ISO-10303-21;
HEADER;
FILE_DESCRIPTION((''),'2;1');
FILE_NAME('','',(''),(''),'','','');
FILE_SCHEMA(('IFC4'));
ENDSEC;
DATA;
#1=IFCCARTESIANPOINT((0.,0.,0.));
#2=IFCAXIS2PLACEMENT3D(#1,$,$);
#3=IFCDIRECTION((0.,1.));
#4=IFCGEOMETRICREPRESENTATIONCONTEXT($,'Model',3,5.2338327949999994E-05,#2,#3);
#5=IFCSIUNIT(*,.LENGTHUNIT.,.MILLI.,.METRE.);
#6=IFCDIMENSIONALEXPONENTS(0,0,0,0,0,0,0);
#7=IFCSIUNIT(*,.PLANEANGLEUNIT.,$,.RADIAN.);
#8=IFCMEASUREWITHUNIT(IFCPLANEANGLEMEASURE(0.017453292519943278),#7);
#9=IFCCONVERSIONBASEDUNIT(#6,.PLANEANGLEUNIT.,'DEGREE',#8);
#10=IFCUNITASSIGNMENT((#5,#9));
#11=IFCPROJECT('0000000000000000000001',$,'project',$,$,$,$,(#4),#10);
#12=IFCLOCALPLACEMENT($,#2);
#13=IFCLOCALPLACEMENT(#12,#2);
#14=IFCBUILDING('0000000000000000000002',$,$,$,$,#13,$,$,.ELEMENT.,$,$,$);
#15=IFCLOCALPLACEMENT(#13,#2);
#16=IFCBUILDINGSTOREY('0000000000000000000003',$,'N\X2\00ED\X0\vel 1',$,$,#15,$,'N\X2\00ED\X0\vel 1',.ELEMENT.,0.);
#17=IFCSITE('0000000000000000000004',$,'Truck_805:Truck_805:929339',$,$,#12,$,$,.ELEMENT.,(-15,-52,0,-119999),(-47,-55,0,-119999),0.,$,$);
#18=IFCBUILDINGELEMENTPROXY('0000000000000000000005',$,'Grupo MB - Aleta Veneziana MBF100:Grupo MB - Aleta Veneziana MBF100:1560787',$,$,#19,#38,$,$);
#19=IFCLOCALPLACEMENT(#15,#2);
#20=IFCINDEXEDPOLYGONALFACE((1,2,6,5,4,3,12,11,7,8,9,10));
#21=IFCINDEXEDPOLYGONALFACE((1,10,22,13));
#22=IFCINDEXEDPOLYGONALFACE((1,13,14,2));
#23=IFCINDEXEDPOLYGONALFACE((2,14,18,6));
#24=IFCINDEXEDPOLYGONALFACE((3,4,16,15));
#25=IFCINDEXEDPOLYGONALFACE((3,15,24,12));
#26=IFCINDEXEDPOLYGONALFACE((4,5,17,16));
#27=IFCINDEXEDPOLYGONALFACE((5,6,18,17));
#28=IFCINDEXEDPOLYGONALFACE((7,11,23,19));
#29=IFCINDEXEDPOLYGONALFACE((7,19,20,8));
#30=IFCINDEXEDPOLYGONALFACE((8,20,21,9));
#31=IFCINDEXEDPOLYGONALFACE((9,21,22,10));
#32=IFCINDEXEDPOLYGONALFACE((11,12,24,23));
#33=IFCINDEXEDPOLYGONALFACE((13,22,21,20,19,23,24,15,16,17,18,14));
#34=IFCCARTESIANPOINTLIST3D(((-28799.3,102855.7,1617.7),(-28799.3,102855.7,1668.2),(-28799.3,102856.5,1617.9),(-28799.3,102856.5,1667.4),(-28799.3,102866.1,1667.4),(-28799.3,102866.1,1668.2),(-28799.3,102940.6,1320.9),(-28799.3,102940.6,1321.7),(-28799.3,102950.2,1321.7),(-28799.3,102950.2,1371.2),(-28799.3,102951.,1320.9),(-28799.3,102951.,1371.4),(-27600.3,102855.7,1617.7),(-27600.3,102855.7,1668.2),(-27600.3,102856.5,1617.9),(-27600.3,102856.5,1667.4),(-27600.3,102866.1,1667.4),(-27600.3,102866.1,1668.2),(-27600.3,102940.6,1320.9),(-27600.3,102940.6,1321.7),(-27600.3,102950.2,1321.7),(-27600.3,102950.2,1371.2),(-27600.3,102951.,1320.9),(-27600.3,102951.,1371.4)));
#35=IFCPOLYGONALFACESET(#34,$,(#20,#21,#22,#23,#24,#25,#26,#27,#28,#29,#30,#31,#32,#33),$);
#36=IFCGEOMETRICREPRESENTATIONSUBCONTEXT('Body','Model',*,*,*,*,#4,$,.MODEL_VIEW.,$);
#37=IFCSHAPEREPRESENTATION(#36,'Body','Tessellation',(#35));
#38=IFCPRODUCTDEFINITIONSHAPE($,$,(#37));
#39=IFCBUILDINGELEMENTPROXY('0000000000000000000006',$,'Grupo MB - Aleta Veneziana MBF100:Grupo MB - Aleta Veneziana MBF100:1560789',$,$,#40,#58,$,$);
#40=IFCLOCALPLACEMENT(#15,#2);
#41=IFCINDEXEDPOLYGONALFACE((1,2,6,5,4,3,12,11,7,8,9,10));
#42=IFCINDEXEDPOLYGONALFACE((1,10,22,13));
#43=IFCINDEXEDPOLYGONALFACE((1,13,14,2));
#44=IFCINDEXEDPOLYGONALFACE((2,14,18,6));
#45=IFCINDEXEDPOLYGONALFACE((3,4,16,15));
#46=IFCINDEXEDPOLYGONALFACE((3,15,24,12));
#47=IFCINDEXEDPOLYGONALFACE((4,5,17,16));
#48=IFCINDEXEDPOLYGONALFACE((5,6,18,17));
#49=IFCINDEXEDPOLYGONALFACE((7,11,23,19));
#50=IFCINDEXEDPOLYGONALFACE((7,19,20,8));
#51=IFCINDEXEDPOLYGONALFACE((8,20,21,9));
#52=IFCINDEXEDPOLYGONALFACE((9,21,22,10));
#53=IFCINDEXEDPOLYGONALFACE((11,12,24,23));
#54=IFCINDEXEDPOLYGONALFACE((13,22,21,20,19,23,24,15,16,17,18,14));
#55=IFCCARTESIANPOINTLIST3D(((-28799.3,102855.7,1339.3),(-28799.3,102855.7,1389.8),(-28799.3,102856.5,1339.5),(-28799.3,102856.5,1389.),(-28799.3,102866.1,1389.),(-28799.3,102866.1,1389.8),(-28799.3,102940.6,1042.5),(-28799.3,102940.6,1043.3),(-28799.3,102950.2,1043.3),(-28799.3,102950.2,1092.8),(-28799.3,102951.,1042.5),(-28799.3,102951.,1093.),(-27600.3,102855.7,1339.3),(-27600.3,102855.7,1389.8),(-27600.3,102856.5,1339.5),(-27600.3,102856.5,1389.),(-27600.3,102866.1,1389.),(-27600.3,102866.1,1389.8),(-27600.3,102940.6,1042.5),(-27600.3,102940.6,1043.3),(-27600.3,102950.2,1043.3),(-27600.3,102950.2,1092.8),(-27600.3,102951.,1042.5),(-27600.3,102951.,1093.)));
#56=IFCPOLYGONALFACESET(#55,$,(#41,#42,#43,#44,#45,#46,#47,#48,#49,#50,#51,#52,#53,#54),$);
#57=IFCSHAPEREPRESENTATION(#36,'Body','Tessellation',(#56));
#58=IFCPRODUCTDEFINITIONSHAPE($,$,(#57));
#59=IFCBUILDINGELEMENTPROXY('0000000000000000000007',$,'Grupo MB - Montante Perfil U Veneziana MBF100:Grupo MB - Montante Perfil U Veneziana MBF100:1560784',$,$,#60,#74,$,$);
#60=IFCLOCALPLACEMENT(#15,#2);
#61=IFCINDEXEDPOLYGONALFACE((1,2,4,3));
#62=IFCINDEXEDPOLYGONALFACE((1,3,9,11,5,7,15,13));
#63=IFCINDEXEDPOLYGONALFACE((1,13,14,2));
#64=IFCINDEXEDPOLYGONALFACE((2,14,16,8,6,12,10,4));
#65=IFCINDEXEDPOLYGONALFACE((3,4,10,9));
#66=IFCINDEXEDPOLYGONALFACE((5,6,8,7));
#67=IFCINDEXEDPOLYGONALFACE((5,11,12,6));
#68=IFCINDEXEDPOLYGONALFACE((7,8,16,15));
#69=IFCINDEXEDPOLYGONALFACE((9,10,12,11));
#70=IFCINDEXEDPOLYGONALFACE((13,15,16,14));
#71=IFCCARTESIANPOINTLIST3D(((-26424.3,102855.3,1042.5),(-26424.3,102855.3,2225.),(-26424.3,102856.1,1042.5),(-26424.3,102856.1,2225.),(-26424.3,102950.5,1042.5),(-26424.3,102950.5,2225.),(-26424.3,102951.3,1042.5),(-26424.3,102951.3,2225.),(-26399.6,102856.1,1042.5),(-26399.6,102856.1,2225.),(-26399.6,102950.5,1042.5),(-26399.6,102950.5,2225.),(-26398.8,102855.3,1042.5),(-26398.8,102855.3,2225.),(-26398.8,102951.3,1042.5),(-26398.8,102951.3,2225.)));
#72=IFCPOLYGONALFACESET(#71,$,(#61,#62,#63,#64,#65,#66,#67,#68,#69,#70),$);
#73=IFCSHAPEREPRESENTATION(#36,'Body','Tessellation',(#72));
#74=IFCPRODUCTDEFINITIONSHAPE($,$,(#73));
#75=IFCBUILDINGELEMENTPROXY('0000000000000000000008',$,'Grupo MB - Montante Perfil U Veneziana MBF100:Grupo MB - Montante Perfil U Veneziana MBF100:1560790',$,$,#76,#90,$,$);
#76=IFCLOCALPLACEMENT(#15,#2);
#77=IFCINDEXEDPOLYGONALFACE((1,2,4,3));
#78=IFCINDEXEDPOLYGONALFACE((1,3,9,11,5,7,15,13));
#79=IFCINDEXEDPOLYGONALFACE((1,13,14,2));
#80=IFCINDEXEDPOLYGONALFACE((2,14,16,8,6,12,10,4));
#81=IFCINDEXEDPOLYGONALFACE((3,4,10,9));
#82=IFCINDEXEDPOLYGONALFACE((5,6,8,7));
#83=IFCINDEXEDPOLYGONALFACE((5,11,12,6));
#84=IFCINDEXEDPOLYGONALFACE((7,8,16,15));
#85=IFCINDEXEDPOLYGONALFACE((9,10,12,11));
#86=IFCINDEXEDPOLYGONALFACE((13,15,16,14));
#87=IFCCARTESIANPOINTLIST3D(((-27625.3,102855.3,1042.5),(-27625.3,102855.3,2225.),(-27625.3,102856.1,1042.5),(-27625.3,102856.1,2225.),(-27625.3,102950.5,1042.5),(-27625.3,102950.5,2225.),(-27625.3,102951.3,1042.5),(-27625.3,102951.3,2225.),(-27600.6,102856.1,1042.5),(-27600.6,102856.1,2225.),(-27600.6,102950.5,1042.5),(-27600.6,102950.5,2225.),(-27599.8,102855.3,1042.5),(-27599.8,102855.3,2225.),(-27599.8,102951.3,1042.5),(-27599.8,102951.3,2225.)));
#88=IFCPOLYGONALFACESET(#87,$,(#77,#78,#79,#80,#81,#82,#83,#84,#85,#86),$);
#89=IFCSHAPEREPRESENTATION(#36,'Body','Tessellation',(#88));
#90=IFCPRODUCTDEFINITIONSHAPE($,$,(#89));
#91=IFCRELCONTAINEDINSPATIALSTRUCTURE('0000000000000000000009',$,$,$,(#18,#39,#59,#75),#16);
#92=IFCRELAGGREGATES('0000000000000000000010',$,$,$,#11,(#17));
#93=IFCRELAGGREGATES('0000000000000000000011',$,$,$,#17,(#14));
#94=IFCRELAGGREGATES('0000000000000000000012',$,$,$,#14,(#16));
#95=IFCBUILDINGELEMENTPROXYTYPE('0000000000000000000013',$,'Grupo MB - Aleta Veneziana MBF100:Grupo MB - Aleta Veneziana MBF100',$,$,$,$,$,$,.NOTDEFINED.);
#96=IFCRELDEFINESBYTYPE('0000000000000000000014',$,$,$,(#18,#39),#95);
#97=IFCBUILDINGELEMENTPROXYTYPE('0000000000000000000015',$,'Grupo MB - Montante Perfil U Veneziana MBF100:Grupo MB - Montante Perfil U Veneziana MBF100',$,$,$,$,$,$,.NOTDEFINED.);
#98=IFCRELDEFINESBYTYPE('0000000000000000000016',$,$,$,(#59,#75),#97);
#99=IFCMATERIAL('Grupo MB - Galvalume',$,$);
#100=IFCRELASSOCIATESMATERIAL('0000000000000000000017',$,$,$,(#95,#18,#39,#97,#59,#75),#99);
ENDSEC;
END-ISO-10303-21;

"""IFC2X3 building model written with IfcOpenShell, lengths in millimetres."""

from ifc_helpers import new_model, entity, si_unit, converted_unit, direction, frame, origin, place, context, subcontext, project, spatial, polyline, outline, extrude, source, transform, mapped, material, type_object, type_shapes, element, save


model = new_model("IFC2X3")

# Units and contexts
model_context = context("Model", 3, precision=5.2338327949999994e-05, world=origin(), true_north=direction((0.0, 1.0)))
body_context = subcontext(model_context, "Body", "Model", "MODEL_VIEW")
ifc_project = project(units=[si_unit("LENGTHUNIT", "METRE", prefix="MILLI"), converted_unit("PLANEANGLEUNIT", "DEGREE", entity("IfcPlaneAngleMeasure", 0.017453292519943278), si_unit("PLANEANGLEUNIT", "RADIAN"), dimensions=[0, 0, 0, 0, 0, 0, 0])], contexts=[model_context])

# Site, building, storey
site_placement = place(None, origin())
site = spatial("IfcSite", under=ifc_project, at=site_placement, Name="Truck_805:Truck_805:929339", CompositionType="ELEMENT", RefLatitude=(-15, -52, 0, -119999), RefLongitude=(-47, -55, 0, -119999), RefElevation=0.0)
building_placement = place(site_placement, origin())
building = spatial("IfcBuilding", under=site, at=building_placement, CompositionType="ELEMENT")
storey_placement = place(building_placement, origin())
storey = spatial("IfcBuildingStorey", under=building, at=storey_placement, Name="Nível 1", LongName="Nível 1", CompositionType="ELEMENT", Elevation=0.0)

# Building element proxies
ifc_material_1 = material(Name="Grupo MB - Galvalume")
building_element_proxy_type_1 = type_object("IfcBuildingElementProxyType", Name="Grupo MB - Aleta Veneziana MBF100:Grupo MB - Aleta Veneziana MBF100", PredefinedType="NOTDEFINED", material=ifc_material_1)
shared_shape_1 = source(origin(), body_context, "Body", "SweptSolid", [
    extrude(outline(polyline([(-131.9, -0.4), (132.1, -0.4), (179.2, 17.7), (175.5, 27.4), (174.7, 27.1), (178.2, 18.1), (131.9, 0.4), (-132.1, 0.4), (-179.2, -17.7), (-175.5, -27.4), (-174.7, -27.1), (-178.2, -18.1), (-131.9, -0.4)])), frame((0.0, -47.6, 173.7), z_axis=(1.0, 0.0, 0.0), x_axis=(0.0, 0.357955, 0.933739)), (0.0, 0.0, 1.0), 1199.0),
])
type_shapes(building_element_proxy_type_1, [shared_shape_1])
for number, where, z_axis, x_axis, name in (
    (1, (-27600.3, 102855.7, 1320.9), (0.0, 0.0, 1.0), (-1.0, 0.0, 0.0), "Grupo MB - Aleta Veneziana MBF100:Grupo MB - Aleta Veneziana MBF100:1560787"),
    (2, (-27600.3, 102855.7, 1042.5), (0.0, 0.0, 1.0), (-1.0, 0.0, 0.0), "Grupo MB - Aleta Veneziana MBF100:Grupo MB - Aleta Veneziana MBF100:1560789"),
):
    element("IfcBuildingElementProxy", number, at=place(storey_placement, frame(where, z_axis=z_axis, x_axis=x_axis)), inside=storey, type_object=building_element_proxy_type_1, material=ifc_material_1, Name=name, context=body_context, shape_type="MappedRepresentation", body=[
        mapped(shared_shape_1, transform((0.0, 0.0, 0.0), scale=1.0)),
    ])
building_element_proxy_type_2 = type_object("IfcBuildingElementProxyType", Name="Grupo MB - Montante Perfil U Veneziana MBF100:Grupo MB - Montante Perfil U Veneziana MBF100", PredefinedType="NOTDEFINED", material=ifc_material_1)
shared_shape_2 = source(origin(), body_context, "Body", "SweptSolid", [
    extrude(outline(polyline([(-48.0, -13.0), (48.0, -13.0), (48.0, 12.6), (47.2, 12.6), (47.2, -12.2), (-47.2, -12.2), (-47.2, 12.6), (-48.0, 12.6), (-48.0, -13.0)])), frame((0.0, -48.0, 13.0), z_axis=(1.0, 0.0, 0.0), x_axis=(0.0, 1.0, 0.0)), (0.0, 0.0, 1.0), 1182.5),
])
type_shapes(building_element_proxy_type_2, [shared_shape_2])
for number, where, z_axis, x_axis, name in (
    (3, (-26398.8, 102951.3, 1042.5), (-1.0, 0.0, 0.0), (0.0, 0.0, 1.0), "Grupo MB - Montante Perfil U Veneziana MBF100:Grupo MB - Montante Perfil U Veneziana MBF100:1560784"),
    (4, (-27599.8, 102951.3, 1042.5), (-1.0, 0.0, 0.0), (0.0, 0.0, 1.0), "Grupo MB - Montante Perfil U Veneziana MBF100:Grupo MB - Montante Perfil U Veneziana MBF100:1560790"),
):
    element("IfcBuildingElementProxy", number, at=place(storey_placement, frame(where, z_axis=z_axis, x_axis=x_axis)), inside=storey, type_object=building_element_proxy_type_2, material=ifc_material_1, Name=name, context=body_context, shape_type="MappedRepresentation", body=[
        mapped(shared_shape_2, transform((0.0, 0.0, 0.0), scale=1.0)),
    ])

save(model, "model.ifc")
